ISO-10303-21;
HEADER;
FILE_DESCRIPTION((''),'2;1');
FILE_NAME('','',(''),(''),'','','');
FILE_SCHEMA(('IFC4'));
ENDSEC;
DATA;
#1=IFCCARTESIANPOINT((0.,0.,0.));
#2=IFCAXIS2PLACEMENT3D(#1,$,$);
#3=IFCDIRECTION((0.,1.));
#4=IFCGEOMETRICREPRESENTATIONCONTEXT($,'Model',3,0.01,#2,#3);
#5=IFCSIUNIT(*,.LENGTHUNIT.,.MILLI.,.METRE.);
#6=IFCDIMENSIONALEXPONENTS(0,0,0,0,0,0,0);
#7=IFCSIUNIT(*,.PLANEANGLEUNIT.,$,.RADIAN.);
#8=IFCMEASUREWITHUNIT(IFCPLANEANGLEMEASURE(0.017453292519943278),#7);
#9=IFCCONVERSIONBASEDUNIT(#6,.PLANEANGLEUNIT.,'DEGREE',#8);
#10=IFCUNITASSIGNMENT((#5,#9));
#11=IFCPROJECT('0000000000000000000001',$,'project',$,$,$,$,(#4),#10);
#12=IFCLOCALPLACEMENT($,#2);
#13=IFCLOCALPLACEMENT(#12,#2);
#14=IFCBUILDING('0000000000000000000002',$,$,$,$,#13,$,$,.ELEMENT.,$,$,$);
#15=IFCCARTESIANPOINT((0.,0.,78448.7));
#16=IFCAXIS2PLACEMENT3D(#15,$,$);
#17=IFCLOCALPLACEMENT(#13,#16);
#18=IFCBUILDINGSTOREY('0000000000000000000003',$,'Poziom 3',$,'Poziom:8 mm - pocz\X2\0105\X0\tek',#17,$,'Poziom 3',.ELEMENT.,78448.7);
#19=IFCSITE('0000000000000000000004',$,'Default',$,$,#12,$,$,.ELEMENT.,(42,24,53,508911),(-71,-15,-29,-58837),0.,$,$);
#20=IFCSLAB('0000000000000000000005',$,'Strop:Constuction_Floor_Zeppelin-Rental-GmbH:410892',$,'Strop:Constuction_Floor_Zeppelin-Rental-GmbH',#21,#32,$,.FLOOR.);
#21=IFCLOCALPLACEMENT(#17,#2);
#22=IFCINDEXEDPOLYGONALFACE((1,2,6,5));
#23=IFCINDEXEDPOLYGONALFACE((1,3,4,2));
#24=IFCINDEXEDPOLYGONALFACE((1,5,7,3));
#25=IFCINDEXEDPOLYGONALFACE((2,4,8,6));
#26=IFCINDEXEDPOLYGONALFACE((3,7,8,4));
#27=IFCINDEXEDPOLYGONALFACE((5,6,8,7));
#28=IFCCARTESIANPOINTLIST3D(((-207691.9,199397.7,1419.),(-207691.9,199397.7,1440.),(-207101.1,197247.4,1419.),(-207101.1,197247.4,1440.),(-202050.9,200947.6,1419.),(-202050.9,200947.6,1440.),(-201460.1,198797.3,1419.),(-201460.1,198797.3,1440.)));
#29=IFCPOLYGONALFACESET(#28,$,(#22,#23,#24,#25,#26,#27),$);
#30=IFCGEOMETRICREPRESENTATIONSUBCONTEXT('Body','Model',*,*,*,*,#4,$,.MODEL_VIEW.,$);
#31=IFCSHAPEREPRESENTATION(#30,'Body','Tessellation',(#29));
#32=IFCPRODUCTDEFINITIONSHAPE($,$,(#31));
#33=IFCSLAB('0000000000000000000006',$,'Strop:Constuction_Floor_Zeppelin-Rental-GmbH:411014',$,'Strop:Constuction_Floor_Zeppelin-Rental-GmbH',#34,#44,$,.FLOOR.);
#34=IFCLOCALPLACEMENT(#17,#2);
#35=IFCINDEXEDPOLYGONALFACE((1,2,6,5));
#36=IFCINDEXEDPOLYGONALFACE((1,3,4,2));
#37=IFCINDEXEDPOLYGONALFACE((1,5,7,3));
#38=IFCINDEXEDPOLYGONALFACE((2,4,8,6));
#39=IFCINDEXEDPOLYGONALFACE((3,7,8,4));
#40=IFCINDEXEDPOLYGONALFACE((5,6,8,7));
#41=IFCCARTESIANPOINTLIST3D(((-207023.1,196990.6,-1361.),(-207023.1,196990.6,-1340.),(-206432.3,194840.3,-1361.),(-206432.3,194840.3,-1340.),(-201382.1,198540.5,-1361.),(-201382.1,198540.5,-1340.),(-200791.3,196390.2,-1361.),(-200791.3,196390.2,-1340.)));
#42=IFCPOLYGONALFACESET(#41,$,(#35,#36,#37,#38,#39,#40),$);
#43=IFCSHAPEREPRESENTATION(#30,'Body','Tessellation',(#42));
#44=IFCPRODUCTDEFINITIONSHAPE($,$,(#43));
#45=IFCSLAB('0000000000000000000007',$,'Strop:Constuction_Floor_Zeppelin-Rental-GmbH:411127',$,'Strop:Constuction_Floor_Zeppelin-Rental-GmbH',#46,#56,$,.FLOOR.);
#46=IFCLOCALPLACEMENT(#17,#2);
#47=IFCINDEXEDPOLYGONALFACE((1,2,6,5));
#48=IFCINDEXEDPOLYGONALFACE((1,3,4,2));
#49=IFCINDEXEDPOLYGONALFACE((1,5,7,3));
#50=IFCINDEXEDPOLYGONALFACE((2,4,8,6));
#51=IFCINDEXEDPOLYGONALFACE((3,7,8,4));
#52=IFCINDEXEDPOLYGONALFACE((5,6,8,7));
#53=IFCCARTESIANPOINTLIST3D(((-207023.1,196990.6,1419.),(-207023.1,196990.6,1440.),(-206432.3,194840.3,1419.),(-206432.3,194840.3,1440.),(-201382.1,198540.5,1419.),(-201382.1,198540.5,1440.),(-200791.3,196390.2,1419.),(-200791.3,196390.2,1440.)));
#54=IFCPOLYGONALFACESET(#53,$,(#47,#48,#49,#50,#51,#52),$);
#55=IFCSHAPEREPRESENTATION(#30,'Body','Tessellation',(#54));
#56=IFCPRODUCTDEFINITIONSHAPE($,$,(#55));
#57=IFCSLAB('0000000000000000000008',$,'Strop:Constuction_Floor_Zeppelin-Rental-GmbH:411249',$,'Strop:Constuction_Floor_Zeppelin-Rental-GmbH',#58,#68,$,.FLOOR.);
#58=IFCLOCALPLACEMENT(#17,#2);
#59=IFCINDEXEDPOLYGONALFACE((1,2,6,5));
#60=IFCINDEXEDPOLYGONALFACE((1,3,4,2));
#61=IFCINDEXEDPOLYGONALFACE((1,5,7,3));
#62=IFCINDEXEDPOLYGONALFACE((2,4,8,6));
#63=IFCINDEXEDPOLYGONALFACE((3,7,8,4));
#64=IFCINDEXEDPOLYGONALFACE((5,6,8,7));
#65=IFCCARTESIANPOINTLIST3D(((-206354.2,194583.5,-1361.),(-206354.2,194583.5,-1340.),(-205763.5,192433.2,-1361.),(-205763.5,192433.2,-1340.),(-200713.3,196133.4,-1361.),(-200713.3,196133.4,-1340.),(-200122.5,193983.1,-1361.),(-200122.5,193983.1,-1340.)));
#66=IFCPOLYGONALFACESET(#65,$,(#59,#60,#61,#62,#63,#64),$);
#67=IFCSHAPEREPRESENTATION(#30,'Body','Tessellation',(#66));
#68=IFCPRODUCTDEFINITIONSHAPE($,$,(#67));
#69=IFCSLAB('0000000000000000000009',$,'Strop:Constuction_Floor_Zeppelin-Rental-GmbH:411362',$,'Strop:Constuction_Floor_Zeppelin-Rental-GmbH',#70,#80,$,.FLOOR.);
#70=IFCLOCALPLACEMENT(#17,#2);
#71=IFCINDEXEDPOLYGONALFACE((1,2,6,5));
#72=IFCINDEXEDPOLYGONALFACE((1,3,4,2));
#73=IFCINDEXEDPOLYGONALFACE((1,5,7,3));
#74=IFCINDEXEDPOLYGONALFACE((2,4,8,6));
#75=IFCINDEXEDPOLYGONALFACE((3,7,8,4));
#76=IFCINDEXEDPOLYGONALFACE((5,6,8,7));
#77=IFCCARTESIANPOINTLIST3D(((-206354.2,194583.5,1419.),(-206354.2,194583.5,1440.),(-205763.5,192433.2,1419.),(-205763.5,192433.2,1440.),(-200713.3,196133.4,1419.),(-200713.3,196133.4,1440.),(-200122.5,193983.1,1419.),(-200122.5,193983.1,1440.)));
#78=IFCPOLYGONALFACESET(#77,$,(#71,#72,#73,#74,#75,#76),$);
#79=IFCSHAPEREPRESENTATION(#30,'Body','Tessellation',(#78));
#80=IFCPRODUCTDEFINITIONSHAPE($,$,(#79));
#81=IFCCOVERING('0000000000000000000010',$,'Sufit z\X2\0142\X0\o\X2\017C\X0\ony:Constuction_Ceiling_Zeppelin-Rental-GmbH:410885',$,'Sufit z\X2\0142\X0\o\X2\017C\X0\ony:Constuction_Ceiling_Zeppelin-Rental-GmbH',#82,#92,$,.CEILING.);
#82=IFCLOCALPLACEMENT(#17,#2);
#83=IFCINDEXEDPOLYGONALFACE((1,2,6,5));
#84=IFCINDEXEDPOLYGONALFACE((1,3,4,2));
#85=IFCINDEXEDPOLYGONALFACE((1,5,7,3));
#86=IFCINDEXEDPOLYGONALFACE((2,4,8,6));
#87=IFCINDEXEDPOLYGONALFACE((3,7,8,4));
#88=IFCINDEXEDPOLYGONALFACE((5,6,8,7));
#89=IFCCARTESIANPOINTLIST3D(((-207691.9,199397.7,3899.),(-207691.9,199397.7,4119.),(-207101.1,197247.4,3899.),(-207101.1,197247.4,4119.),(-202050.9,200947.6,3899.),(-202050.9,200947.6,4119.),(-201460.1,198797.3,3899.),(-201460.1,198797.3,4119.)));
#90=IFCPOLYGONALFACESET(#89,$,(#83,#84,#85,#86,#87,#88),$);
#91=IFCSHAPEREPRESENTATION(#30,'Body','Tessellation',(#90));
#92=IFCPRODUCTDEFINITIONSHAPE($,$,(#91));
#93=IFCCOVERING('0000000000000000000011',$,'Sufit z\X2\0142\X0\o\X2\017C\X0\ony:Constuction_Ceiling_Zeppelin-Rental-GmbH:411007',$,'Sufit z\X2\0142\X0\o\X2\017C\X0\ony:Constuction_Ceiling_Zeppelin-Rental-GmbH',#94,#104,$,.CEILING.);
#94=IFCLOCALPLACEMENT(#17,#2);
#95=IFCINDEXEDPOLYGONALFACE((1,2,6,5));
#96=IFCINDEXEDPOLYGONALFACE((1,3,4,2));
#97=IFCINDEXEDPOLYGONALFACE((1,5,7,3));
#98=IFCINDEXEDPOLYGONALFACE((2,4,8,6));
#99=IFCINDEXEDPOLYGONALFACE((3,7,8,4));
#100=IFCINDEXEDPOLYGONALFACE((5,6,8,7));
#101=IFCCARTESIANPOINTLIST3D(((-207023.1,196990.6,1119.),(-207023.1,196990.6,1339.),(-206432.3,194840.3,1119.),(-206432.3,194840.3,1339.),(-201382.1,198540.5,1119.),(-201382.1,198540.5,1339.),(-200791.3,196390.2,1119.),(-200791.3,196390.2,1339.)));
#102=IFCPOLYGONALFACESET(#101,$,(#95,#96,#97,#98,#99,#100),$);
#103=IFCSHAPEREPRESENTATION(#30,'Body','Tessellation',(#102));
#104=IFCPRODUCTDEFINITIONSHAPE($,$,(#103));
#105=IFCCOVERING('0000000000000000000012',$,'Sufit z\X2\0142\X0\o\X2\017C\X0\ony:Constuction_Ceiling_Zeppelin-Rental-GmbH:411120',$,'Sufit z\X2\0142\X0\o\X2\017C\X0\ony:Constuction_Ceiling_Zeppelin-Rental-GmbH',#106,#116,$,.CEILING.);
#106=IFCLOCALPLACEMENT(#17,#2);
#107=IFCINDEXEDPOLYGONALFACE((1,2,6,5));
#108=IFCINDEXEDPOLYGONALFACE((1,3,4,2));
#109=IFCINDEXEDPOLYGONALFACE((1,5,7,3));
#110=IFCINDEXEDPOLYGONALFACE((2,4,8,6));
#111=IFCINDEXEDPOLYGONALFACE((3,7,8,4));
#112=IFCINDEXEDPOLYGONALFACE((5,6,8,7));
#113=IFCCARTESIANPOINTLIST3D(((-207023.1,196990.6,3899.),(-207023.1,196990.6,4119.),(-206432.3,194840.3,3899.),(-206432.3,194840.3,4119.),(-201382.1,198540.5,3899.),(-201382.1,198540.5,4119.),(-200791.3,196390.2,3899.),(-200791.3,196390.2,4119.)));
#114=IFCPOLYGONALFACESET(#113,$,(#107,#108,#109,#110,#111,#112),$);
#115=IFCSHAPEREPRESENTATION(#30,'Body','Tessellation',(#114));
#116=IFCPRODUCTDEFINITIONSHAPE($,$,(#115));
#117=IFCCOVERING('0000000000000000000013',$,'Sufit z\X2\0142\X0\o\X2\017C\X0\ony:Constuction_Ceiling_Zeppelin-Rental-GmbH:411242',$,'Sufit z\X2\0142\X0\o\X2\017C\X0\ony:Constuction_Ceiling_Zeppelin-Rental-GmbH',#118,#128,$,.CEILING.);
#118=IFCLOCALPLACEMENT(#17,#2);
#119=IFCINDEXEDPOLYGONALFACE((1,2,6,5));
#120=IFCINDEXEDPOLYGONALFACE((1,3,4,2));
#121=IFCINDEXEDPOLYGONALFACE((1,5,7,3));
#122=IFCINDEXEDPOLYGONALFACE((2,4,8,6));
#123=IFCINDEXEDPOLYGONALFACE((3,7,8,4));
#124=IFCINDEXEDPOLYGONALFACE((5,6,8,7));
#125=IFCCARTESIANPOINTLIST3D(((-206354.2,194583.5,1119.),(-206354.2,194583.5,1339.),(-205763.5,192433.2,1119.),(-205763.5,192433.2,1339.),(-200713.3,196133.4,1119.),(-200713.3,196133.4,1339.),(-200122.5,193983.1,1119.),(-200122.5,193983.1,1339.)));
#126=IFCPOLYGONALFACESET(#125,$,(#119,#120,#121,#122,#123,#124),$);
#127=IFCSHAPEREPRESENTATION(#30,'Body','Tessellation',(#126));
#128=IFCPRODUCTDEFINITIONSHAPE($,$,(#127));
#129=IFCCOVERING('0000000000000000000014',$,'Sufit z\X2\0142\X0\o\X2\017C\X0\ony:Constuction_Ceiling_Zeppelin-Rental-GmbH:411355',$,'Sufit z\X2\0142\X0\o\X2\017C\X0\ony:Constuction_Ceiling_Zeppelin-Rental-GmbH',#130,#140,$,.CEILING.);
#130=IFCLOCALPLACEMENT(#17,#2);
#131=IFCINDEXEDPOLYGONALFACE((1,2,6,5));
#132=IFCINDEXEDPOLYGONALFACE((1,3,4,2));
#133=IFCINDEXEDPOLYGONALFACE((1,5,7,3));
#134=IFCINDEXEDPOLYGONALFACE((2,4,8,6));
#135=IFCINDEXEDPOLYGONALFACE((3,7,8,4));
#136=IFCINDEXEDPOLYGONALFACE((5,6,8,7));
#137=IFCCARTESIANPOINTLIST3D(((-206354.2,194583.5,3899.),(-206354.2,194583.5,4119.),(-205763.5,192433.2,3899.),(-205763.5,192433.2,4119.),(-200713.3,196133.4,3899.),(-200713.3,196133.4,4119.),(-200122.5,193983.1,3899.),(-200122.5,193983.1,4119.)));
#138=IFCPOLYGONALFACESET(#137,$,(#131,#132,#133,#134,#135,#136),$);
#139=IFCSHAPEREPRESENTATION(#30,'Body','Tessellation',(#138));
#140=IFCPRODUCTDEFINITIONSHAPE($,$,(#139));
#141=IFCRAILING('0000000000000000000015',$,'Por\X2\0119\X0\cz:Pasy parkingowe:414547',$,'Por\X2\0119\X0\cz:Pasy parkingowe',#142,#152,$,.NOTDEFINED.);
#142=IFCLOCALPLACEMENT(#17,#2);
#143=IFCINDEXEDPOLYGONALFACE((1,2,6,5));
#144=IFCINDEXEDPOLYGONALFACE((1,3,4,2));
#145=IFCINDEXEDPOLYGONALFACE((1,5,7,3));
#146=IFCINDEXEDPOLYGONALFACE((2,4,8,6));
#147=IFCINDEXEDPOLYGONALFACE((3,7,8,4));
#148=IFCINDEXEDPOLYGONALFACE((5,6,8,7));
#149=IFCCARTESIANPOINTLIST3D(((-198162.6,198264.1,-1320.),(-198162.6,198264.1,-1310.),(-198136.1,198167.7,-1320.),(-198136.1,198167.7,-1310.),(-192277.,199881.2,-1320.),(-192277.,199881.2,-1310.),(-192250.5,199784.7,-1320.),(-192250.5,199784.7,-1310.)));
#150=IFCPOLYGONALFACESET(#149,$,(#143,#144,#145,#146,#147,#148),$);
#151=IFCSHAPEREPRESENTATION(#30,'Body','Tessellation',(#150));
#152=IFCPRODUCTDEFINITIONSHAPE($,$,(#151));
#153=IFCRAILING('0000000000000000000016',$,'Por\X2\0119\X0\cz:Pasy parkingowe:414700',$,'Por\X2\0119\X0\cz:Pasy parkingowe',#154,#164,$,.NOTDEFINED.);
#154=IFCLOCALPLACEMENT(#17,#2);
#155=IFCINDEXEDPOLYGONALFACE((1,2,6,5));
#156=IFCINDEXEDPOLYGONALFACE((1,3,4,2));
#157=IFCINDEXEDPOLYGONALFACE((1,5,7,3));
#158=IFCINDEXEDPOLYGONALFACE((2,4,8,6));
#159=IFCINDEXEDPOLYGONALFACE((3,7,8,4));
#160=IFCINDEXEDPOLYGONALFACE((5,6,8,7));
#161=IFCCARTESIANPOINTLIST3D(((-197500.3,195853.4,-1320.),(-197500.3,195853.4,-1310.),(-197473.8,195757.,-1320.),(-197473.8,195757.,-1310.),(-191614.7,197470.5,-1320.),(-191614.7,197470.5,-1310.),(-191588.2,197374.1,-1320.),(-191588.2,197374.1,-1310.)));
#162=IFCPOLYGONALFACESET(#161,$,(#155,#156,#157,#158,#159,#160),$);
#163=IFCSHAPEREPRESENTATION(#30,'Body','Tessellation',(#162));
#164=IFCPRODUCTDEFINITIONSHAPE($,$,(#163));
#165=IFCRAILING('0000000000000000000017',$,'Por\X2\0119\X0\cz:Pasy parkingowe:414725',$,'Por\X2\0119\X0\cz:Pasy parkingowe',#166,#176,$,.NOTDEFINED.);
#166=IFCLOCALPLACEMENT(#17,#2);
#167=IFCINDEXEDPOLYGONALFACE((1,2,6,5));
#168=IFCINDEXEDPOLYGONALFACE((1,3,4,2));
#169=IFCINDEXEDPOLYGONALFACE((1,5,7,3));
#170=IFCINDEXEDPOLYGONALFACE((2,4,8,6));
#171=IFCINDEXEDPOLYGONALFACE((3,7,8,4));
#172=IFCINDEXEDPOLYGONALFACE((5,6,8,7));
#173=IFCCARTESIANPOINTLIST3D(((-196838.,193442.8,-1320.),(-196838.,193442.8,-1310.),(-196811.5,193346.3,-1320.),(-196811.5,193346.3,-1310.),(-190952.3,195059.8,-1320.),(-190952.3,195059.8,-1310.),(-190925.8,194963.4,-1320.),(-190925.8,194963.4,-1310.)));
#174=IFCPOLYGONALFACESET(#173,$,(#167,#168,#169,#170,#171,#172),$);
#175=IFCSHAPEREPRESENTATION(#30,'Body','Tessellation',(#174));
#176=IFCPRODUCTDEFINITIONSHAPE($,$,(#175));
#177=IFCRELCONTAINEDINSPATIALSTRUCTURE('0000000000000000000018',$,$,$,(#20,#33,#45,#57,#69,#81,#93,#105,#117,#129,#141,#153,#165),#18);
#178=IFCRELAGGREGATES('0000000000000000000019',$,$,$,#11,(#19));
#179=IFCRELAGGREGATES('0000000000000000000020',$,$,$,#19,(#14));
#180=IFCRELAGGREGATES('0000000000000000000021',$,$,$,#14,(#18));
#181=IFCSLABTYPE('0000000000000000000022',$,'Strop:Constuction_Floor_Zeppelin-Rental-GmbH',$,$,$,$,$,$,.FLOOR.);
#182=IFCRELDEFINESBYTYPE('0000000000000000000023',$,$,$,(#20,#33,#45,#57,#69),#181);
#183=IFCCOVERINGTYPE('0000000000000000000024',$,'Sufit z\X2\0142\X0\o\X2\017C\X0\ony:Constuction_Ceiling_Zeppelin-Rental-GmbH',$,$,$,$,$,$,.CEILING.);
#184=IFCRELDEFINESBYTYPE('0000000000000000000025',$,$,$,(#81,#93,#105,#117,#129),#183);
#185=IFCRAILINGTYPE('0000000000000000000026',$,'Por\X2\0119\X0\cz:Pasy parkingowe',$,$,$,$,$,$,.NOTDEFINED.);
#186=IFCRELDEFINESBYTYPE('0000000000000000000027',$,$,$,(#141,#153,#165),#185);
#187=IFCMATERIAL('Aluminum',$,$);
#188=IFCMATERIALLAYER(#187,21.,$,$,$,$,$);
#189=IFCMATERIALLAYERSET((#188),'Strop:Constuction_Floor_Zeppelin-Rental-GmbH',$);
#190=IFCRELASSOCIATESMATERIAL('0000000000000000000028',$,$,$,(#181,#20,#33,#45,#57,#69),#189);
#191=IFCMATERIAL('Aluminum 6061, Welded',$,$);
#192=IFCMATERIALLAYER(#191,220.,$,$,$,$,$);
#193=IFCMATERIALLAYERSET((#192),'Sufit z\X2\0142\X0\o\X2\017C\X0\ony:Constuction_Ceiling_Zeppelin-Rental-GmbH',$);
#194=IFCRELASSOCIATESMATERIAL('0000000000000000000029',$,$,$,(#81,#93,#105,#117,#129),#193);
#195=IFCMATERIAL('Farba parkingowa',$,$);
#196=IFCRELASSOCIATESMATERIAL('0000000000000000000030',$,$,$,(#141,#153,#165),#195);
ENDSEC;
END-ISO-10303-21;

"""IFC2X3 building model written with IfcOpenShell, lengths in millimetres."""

from ifc_helpers import new_model, entity, si_unit, converted_unit, direction, frame, frame_2d, origin, place, context, subcontext, project, spatial, rectangle, extrude, material, layer, layer_set, layer_usage, type_object, element, save


model = new_model("IFC2X3")

# Units and contexts
model_context = context("Model", 3, precision=0.01, world=origin(), true_north=direction((0.0, 1.0)))
body_context = subcontext(model_context, "Body", "Model", "MODEL_VIEW")
ifc_project = project(units=[si_unit("LENGTHUNIT", "METRE", prefix="MILLI"), converted_unit("PLANEANGLEUNIT", "DEGREE", entity("IfcPlaneAngleMeasure", 0.017453292519943278), si_unit("PLANEANGLEUNIT", "RADIAN"), dimensions=[0, 0, 0, 0, 0, 0, 0])], contexts=[model_context])

# Site, building, storey
site_placement = place(None, origin())
site = spatial("IfcSite", under=ifc_project, at=site_placement, Name="Default", CompositionType="ELEMENT", RefLatitude=(42, 24, 53, 508911), RefLongitude=(-71, -15, -29, -58837), RefElevation=0.0)
building_placement = place(site_placement, origin())
building = spatial("IfcBuilding", under=site, at=building_placement, CompositionType="ELEMENT")
storey_placement = place(building_placement, frame((0.0, 0.0, 78448.7)))
storey = spatial("IfcBuildingStorey", under=building, at=storey_placement, Name="Poziom 3", ObjectType="Poziom:8 mm - początek", LongName="Poziom 3", CompositionType="ELEMENT", Elevation=78448.7)

# Slabs
ifc_material_1 = material(Name="Aluminum")
ifc_layer_1 = layer(ifc_material_1, 21.0)
ifc_layer_set_1 = layer_set([ifc_layer_1], Name="Strop:Constuction_Floor_Zeppelin-Rental-GmbH")
ifc_layer_usage_1 = layer_usage(ifc_layer_set_1, "AXIS3", "POSITIVE", 0.0)
slab_type_1 = type_object("IfcSlabType", Name="Strop:Constuction_Floor_Zeppelin-Rental-GmbH", PredefinedType="FLOOR", material=ifc_layer_set_1)
slab_1_placement = place(storey_placement, origin())
element("IfcSlab", 1, at=slab_1_placement, inside=storey, type_object=slab_type_1, material=ifc_layer_usage_1, Name="Strop:Constuction_Floor_Zeppelin-Rental-GmbH:410892", ObjectType="Strop:Constuction_Floor_Zeppelin-Rental-GmbH", PredefinedType="FLOOR", context=body_context, shape_type="SweptSolid", body=[
    extrude(rectangle(XDim=5850.0, YDim=2230.0, at=frame_2d((0.0, 0.0), x_axis=(1.0, 0.0))), frame((-204576.0, 199097.5, 1440.0), z_axis=(0.0, 0.0, -1.0), x_axis=(0.964267, 0.264931, 0.0)), (0.0, 0.0, 1.0), 21.0),
])
ifc_layer_usage_2 = layer_usage(ifc_layer_set_1, "AXIS3", "POSITIVE", 0.0)
slab_2_placement = place(storey_placement, origin())
element("IfcSlab", 2, at=slab_2_placement, inside=storey, type_object=slab_type_1, material=ifc_layer_usage_2, Name="Strop:Constuction_Floor_Zeppelin-Rental-GmbH:411014", ObjectType="Strop:Constuction_Floor_Zeppelin-Rental-GmbH", PredefinedType="FLOOR", context=body_context, shape_type="SweptSolid", body=[
    extrude(rectangle(XDim=5850.0, YDim=2230.0, at=frame_2d((0.0, 0.0), x_axis=(1.0, 0.0))), frame((-203907.2, 196690.4, -1340.0), z_axis=(0.0, 0.0, -1.0), x_axis=(0.964267, 0.264931, 0.0)), (0.0, 0.0, 1.0), 21.0),
])
ifc_layer_usage_3 = layer_usage(ifc_layer_set_1, "AXIS3", "POSITIVE", 0.0)
slab_3_placement = place(storey_placement, origin())
element("IfcSlab", 3, at=slab_3_placement, inside=storey, type_object=slab_type_1, material=ifc_layer_usage_3, Name="Strop:Constuction_Floor_Zeppelin-Rental-GmbH:411127", ObjectType="Strop:Constuction_Floor_Zeppelin-Rental-GmbH", PredefinedType="FLOOR", context=body_context, shape_type="SweptSolid", body=[
    extrude(rectangle(XDim=5850.0, YDim=2230.0, at=frame_2d((0.0, 0.0), x_axis=(1.0, 0.0))), frame((-203907.2, 196690.4, 1440.0), z_axis=(0.0, 0.0, -1.0), x_axis=(0.964267, 0.264931, 0.0)), (0.0, 0.0, 1.0), 21.0),
])
ifc_layer_usage_4 = layer_usage(ifc_layer_set_1, "AXIS3", "POSITIVE", 0.0)
slab_4_placement = place(storey_placement, origin())
element("IfcSlab", 4, at=slab_4_placement, inside=storey, type_object=slab_type_1, material=ifc_layer_usage_4, Name="Strop:Constuction_Floor_Zeppelin-Rental-GmbH:411249", ObjectType="Strop:Constuction_Floor_Zeppelin-Rental-GmbH", PredefinedType="FLOOR", context=body_context, shape_type="SweptSolid", body=[
    extrude(rectangle(XDim=5850.0, YDim=2230.0, at=frame_2d((0.0, 0.0), x_axis=(1.0, 0.0))), frame((-203238.4, 194283.3, -1340.0), z_axis=(0.0, 0.0, -1.0), x_axis=(0.964267, 0.264931, 0.0)), (0.0, 0.0, 1.0), 21.0),
])
ifc_layer_usage_5 = layer_usage(ifc_layer_set_1, "AXIS3", "POSITIVE", 0.0)
slab_5_placement = place(storey_placement, origin())
element("IfcSlab", 5, at=slab_5_placement, inside=storey, type_object=slab_type_1, material=ifc_layer_usage_5, Name="Strop:Constuction_Floor_Zeppelin-Rental-GmbH:411362", ObjectType="Strop:Constuction_Floor_Zeppelin-Rental-GmbH", PredefinedType="FLOOR", context=body_context, shape_type="SweptSolid", body=[
    extrude(rectangle(XDim=5850.0, YDim=2230.0, at=frame_2d((0.0, 0.0), x_axis=(1.0, 0.0))), frame((-203238.4, 194283.3, 1440.0), z_axis=(0.0, 0.0, -1.0), x_axis=(0.964267, 0.264931, 0.0)), (0.0, 0.0, 1.0), 21.0),
])

# Coverings
ifc_material_2 = material(Name="Aluminum 6061, Welded")
ifc_layer_2 = layer(ifc_material_2, 220.0)
ifc_layer_set_2 = layer_set([ifc_layer_2], Name="Sufit złożony:Constuction_Ceiling_Zeppelin-Rental-GmbH")
ifc_layer_usage_6 = layer_usage(ifc_layer_set_2, "AXIS3", "NEGATIVE", 220.0)
covering_type = type_object("IfcCoveringType", Name="Sufit złożony:Constuction_Ceiling_Zeppelin-Rental-GmbH", PredefinedType="CEILING")
covering_1_placement = place(storey_placement, origin())
element("IfcCovering", 6, at=covering_1_placement, inside=storey, type_object=covering_type, material=ifc_layer_usage_6, Name="Sufit złożony:Constuction_Ceiling_Zeppelin-Rental-GmbH:410885", ObjectType="Sufit złożony:Constuction_Ceiling_Zeppelin-Rental-GmbH", PredefinedType="CEILING", context=body_context, shape_type="SweptSolid", body=[
    extrude(rectangle(XDim=5850.0, YDim=2230.0, at=frame_2d((0.0, 0.0), x_axis=(1.0, 0.0))), frame((-204576.0, 199097.5, 3899.0), z_axis=(0.0, 0.0, 1.0), x_axis=(-0.964267, -0.264931, 0.0)), (0.0, 0.0, 1.0), 220.0),
])
ifc_layer_usage_7 = layer_usage(ifc_layer_set_2, "AXIS3", "NEGATIVE", 220.0)
covering_2_placement = place(storey_placement, origin())
element("IfcCovering", 7, at=covering_2_placement, inside=storey, type_object=covering_type, material=ifc_layer_usage_7, Name="Sufit złożony:Constuction_Ceiling_Zeppelin-Rental-GmbH:411007", ObjectType="Sufit złożony:Constuction_Ceiling_Zeppelin-Rental-GmbH", PredefinedType="CEILING", context=body_context, shape_type="SweptSolid", body=[
    extrude(rectangle(XDim=5850.0, YDim=2230.0, at=frame_2d((0.0, 0.0), x_axis=(1.0, 0.0))), frame((-203907.2, 196690.4, 1119.0), z_axis=(0.0, 0.0, 1.0), x_axis=(-0.964267, -0.264931, 0.0)), (0.0, 0.0, 1.0), 220.0),
])
ifc_layer_usage_8 = layer_usage(ifc_layer_set_2, "AXIS3", "NEGATIVE", 220.0)
covering_3_placement = place(storey_placement, origin())
element("IfcCovering", 8, at=covering_3_placement, inside=storey, type_object=covering_type, material=ifc_layer_usage_8, Name="Sufit złożony:Constuction_Ceiling_Zeppelin-Rental-GmbH:411120", ObjectType="Sufit złożony:Constuction_Ceiling_Zeppelin-Rental-GmbH", PredefinedType="CEILING", context=body_context, shape_type="SweptSolid", body=[
    extrude(rectangle(XDim=5850.0, YDim=2230.0, at=frame_2d((0.0, 0.0), x_axis=(1.0, 0.0))), frame((-203907.2, 196690.4, 3899.0), z_axis=(0.0, 0.0, 1.0), x_axis=(-0.964267, -0.264931, 0.0)), (0.0, 0.0, 1.0), 220.0),
])
ifc_layer_usage_9 = layer_usage(ifc_layer_set_2, "AXIS3", "NEGATIVE", 220.0)
covering_4_placement = place(storey_placement, origin())
element("IfcCovering", 9, at=covering_4_placement, inside=storey, type_object=covering_type, material=ifc_layer_usage_9, Name="Sufit złożony:Constuction_Ceiling_Zeppelin-Rental-GmbH:411242", ObjectType="Sufit złożony:Constuction_Ceiling_Zeppelin-Rental-GmbH", PredefinedType="CEILING", context=body_context, shape_type="SweptSolid", body=[
    extrude(rectangle(XDim=5850.0, YDim=2230.0, at=frame_2d((0.0, 0.0), x_axis=(1.0, 0.0))), frame((-203238.4, 194283.3, 1119.0), z_axis=(0.0, 0.0, 1.0), x_axis=(-0.964267, -0.264931, 0.0)), (0.0, 0.0, 1.0), 220.0),
])
ifc_layer_usage_10 = layer_usage(ifc_layer_set_2, "AXIS3", "NEGATIVE", 220.0)
covering_5_placement = place(storey_placement, origin())
element("IfcCovering", 10, at=covering_5_placement, inside=storey, type_object=covering_type, material=ifc_layer_usage_10, Name="Sufit złożony:Constuction_Ceiling_Zeppelin-Rental-GmbH:411355", ObjectType="Sufit złożony:Constuction_Ceiling_Zeppelin-Rental-GmbH", PredefinedType="CEILING", context=body_context, shape_type="SweptSolid", body=[
    extrude(rectangle(XDim=5850.0, YDim=2230.0, at=frame_2d((0.0, 0.0), x_axis=(1.0, 0.0))), frame((-203238.4, 194283.3, 3899.0), z_axis=(0.0, 0.0, 1.0), x_axis=(-0.964267, -0.264931, 0.0)), (0.0, 0.0, 1.0), 220.0),
])

# Railings
ifc_material_3 = material(Name="Farba parkingowa")
railing_type = type_object("IfcRailingType", Name="Poręcz:Pasy parkingowe", PredefinedType="NOTDEFINED")
railing_1_placement = place(storey_placement, origin())
element("IfcRailing", 11, at=railing_1_placement, inside=storey, type_object=railing_type, material=ifc_material_3, Name="Poręcz:Pasy parkingowe:414547", ObjectType="Poręcz:Pasy parkingowe", PredefinedType="NOTDEFINED", context=body_context, shape_type="SweptSolid", body=[
    extrude(rectangle(XDim=6103.7, YDim=100.0, at=frame_2d((0.0, 0.0), x_axis=(1.0, 0.0))), frame((-195206.6, 199024.4, -1320.0), z_axis=(0.0, 0.0, 1.0), x_axis=(0.964267, 0.264931, 0.0)), (0.0, 0.0, 1.0), 10.0),
])
railing_2_placement = place(storey_placement, origin())
element("IfcRailing", 12, at=railing_2_placement, inside=storey, type_object=railing_type, material=ifc_material_3, Name="Poręcz:Pasy parkingowe:414700", ObjectType="Poręcz:Pasy parkingowe", PredefinedType="NOTDEFINED", context=body_context, shape_type="SweptSolid", body=[
    extrude(rectangle(XDim=6103.7, YDim=100.0, at=frame_2d((0.0, 0.0), x_axis=(1.0, 0.0))), frame((-194544.2, 196613.8, -1320.0), z_axis=(0.0, 0.0, 1.0), x_axis=(0.964267, 0.264931, 0.0)), (0.0, 0.0, 1.0), 10.0),
])
railing_3_placement = place(storey_placement, origin())
element("IfcRailing", 13, at=railing_3_placement, inside=storey, type_object=railing_type, material=ifc_material_3, Name="Poręcz:Pasy parkingowe:414725", ObjectType="Poręcz:Pasy parkingowe", PredefinedType="NOTDEFINED", context=body_context, shape_type="SweptSolid", body=[
    extrude(rectangle(XDim=6103.7, YDim=100.0, at=frame_2d((0.0, 0.0), x_axis=(1.0, 0.0))), frame((-193881.9, 194203.1, -1320.0), z_axis=(0.0, 0.0, 1.0), x_axis=(0.964267, 0.264931, 0.0)), (0.0, 0.0, 1.0), 10.0),
])

save(model, "model.ifc")
